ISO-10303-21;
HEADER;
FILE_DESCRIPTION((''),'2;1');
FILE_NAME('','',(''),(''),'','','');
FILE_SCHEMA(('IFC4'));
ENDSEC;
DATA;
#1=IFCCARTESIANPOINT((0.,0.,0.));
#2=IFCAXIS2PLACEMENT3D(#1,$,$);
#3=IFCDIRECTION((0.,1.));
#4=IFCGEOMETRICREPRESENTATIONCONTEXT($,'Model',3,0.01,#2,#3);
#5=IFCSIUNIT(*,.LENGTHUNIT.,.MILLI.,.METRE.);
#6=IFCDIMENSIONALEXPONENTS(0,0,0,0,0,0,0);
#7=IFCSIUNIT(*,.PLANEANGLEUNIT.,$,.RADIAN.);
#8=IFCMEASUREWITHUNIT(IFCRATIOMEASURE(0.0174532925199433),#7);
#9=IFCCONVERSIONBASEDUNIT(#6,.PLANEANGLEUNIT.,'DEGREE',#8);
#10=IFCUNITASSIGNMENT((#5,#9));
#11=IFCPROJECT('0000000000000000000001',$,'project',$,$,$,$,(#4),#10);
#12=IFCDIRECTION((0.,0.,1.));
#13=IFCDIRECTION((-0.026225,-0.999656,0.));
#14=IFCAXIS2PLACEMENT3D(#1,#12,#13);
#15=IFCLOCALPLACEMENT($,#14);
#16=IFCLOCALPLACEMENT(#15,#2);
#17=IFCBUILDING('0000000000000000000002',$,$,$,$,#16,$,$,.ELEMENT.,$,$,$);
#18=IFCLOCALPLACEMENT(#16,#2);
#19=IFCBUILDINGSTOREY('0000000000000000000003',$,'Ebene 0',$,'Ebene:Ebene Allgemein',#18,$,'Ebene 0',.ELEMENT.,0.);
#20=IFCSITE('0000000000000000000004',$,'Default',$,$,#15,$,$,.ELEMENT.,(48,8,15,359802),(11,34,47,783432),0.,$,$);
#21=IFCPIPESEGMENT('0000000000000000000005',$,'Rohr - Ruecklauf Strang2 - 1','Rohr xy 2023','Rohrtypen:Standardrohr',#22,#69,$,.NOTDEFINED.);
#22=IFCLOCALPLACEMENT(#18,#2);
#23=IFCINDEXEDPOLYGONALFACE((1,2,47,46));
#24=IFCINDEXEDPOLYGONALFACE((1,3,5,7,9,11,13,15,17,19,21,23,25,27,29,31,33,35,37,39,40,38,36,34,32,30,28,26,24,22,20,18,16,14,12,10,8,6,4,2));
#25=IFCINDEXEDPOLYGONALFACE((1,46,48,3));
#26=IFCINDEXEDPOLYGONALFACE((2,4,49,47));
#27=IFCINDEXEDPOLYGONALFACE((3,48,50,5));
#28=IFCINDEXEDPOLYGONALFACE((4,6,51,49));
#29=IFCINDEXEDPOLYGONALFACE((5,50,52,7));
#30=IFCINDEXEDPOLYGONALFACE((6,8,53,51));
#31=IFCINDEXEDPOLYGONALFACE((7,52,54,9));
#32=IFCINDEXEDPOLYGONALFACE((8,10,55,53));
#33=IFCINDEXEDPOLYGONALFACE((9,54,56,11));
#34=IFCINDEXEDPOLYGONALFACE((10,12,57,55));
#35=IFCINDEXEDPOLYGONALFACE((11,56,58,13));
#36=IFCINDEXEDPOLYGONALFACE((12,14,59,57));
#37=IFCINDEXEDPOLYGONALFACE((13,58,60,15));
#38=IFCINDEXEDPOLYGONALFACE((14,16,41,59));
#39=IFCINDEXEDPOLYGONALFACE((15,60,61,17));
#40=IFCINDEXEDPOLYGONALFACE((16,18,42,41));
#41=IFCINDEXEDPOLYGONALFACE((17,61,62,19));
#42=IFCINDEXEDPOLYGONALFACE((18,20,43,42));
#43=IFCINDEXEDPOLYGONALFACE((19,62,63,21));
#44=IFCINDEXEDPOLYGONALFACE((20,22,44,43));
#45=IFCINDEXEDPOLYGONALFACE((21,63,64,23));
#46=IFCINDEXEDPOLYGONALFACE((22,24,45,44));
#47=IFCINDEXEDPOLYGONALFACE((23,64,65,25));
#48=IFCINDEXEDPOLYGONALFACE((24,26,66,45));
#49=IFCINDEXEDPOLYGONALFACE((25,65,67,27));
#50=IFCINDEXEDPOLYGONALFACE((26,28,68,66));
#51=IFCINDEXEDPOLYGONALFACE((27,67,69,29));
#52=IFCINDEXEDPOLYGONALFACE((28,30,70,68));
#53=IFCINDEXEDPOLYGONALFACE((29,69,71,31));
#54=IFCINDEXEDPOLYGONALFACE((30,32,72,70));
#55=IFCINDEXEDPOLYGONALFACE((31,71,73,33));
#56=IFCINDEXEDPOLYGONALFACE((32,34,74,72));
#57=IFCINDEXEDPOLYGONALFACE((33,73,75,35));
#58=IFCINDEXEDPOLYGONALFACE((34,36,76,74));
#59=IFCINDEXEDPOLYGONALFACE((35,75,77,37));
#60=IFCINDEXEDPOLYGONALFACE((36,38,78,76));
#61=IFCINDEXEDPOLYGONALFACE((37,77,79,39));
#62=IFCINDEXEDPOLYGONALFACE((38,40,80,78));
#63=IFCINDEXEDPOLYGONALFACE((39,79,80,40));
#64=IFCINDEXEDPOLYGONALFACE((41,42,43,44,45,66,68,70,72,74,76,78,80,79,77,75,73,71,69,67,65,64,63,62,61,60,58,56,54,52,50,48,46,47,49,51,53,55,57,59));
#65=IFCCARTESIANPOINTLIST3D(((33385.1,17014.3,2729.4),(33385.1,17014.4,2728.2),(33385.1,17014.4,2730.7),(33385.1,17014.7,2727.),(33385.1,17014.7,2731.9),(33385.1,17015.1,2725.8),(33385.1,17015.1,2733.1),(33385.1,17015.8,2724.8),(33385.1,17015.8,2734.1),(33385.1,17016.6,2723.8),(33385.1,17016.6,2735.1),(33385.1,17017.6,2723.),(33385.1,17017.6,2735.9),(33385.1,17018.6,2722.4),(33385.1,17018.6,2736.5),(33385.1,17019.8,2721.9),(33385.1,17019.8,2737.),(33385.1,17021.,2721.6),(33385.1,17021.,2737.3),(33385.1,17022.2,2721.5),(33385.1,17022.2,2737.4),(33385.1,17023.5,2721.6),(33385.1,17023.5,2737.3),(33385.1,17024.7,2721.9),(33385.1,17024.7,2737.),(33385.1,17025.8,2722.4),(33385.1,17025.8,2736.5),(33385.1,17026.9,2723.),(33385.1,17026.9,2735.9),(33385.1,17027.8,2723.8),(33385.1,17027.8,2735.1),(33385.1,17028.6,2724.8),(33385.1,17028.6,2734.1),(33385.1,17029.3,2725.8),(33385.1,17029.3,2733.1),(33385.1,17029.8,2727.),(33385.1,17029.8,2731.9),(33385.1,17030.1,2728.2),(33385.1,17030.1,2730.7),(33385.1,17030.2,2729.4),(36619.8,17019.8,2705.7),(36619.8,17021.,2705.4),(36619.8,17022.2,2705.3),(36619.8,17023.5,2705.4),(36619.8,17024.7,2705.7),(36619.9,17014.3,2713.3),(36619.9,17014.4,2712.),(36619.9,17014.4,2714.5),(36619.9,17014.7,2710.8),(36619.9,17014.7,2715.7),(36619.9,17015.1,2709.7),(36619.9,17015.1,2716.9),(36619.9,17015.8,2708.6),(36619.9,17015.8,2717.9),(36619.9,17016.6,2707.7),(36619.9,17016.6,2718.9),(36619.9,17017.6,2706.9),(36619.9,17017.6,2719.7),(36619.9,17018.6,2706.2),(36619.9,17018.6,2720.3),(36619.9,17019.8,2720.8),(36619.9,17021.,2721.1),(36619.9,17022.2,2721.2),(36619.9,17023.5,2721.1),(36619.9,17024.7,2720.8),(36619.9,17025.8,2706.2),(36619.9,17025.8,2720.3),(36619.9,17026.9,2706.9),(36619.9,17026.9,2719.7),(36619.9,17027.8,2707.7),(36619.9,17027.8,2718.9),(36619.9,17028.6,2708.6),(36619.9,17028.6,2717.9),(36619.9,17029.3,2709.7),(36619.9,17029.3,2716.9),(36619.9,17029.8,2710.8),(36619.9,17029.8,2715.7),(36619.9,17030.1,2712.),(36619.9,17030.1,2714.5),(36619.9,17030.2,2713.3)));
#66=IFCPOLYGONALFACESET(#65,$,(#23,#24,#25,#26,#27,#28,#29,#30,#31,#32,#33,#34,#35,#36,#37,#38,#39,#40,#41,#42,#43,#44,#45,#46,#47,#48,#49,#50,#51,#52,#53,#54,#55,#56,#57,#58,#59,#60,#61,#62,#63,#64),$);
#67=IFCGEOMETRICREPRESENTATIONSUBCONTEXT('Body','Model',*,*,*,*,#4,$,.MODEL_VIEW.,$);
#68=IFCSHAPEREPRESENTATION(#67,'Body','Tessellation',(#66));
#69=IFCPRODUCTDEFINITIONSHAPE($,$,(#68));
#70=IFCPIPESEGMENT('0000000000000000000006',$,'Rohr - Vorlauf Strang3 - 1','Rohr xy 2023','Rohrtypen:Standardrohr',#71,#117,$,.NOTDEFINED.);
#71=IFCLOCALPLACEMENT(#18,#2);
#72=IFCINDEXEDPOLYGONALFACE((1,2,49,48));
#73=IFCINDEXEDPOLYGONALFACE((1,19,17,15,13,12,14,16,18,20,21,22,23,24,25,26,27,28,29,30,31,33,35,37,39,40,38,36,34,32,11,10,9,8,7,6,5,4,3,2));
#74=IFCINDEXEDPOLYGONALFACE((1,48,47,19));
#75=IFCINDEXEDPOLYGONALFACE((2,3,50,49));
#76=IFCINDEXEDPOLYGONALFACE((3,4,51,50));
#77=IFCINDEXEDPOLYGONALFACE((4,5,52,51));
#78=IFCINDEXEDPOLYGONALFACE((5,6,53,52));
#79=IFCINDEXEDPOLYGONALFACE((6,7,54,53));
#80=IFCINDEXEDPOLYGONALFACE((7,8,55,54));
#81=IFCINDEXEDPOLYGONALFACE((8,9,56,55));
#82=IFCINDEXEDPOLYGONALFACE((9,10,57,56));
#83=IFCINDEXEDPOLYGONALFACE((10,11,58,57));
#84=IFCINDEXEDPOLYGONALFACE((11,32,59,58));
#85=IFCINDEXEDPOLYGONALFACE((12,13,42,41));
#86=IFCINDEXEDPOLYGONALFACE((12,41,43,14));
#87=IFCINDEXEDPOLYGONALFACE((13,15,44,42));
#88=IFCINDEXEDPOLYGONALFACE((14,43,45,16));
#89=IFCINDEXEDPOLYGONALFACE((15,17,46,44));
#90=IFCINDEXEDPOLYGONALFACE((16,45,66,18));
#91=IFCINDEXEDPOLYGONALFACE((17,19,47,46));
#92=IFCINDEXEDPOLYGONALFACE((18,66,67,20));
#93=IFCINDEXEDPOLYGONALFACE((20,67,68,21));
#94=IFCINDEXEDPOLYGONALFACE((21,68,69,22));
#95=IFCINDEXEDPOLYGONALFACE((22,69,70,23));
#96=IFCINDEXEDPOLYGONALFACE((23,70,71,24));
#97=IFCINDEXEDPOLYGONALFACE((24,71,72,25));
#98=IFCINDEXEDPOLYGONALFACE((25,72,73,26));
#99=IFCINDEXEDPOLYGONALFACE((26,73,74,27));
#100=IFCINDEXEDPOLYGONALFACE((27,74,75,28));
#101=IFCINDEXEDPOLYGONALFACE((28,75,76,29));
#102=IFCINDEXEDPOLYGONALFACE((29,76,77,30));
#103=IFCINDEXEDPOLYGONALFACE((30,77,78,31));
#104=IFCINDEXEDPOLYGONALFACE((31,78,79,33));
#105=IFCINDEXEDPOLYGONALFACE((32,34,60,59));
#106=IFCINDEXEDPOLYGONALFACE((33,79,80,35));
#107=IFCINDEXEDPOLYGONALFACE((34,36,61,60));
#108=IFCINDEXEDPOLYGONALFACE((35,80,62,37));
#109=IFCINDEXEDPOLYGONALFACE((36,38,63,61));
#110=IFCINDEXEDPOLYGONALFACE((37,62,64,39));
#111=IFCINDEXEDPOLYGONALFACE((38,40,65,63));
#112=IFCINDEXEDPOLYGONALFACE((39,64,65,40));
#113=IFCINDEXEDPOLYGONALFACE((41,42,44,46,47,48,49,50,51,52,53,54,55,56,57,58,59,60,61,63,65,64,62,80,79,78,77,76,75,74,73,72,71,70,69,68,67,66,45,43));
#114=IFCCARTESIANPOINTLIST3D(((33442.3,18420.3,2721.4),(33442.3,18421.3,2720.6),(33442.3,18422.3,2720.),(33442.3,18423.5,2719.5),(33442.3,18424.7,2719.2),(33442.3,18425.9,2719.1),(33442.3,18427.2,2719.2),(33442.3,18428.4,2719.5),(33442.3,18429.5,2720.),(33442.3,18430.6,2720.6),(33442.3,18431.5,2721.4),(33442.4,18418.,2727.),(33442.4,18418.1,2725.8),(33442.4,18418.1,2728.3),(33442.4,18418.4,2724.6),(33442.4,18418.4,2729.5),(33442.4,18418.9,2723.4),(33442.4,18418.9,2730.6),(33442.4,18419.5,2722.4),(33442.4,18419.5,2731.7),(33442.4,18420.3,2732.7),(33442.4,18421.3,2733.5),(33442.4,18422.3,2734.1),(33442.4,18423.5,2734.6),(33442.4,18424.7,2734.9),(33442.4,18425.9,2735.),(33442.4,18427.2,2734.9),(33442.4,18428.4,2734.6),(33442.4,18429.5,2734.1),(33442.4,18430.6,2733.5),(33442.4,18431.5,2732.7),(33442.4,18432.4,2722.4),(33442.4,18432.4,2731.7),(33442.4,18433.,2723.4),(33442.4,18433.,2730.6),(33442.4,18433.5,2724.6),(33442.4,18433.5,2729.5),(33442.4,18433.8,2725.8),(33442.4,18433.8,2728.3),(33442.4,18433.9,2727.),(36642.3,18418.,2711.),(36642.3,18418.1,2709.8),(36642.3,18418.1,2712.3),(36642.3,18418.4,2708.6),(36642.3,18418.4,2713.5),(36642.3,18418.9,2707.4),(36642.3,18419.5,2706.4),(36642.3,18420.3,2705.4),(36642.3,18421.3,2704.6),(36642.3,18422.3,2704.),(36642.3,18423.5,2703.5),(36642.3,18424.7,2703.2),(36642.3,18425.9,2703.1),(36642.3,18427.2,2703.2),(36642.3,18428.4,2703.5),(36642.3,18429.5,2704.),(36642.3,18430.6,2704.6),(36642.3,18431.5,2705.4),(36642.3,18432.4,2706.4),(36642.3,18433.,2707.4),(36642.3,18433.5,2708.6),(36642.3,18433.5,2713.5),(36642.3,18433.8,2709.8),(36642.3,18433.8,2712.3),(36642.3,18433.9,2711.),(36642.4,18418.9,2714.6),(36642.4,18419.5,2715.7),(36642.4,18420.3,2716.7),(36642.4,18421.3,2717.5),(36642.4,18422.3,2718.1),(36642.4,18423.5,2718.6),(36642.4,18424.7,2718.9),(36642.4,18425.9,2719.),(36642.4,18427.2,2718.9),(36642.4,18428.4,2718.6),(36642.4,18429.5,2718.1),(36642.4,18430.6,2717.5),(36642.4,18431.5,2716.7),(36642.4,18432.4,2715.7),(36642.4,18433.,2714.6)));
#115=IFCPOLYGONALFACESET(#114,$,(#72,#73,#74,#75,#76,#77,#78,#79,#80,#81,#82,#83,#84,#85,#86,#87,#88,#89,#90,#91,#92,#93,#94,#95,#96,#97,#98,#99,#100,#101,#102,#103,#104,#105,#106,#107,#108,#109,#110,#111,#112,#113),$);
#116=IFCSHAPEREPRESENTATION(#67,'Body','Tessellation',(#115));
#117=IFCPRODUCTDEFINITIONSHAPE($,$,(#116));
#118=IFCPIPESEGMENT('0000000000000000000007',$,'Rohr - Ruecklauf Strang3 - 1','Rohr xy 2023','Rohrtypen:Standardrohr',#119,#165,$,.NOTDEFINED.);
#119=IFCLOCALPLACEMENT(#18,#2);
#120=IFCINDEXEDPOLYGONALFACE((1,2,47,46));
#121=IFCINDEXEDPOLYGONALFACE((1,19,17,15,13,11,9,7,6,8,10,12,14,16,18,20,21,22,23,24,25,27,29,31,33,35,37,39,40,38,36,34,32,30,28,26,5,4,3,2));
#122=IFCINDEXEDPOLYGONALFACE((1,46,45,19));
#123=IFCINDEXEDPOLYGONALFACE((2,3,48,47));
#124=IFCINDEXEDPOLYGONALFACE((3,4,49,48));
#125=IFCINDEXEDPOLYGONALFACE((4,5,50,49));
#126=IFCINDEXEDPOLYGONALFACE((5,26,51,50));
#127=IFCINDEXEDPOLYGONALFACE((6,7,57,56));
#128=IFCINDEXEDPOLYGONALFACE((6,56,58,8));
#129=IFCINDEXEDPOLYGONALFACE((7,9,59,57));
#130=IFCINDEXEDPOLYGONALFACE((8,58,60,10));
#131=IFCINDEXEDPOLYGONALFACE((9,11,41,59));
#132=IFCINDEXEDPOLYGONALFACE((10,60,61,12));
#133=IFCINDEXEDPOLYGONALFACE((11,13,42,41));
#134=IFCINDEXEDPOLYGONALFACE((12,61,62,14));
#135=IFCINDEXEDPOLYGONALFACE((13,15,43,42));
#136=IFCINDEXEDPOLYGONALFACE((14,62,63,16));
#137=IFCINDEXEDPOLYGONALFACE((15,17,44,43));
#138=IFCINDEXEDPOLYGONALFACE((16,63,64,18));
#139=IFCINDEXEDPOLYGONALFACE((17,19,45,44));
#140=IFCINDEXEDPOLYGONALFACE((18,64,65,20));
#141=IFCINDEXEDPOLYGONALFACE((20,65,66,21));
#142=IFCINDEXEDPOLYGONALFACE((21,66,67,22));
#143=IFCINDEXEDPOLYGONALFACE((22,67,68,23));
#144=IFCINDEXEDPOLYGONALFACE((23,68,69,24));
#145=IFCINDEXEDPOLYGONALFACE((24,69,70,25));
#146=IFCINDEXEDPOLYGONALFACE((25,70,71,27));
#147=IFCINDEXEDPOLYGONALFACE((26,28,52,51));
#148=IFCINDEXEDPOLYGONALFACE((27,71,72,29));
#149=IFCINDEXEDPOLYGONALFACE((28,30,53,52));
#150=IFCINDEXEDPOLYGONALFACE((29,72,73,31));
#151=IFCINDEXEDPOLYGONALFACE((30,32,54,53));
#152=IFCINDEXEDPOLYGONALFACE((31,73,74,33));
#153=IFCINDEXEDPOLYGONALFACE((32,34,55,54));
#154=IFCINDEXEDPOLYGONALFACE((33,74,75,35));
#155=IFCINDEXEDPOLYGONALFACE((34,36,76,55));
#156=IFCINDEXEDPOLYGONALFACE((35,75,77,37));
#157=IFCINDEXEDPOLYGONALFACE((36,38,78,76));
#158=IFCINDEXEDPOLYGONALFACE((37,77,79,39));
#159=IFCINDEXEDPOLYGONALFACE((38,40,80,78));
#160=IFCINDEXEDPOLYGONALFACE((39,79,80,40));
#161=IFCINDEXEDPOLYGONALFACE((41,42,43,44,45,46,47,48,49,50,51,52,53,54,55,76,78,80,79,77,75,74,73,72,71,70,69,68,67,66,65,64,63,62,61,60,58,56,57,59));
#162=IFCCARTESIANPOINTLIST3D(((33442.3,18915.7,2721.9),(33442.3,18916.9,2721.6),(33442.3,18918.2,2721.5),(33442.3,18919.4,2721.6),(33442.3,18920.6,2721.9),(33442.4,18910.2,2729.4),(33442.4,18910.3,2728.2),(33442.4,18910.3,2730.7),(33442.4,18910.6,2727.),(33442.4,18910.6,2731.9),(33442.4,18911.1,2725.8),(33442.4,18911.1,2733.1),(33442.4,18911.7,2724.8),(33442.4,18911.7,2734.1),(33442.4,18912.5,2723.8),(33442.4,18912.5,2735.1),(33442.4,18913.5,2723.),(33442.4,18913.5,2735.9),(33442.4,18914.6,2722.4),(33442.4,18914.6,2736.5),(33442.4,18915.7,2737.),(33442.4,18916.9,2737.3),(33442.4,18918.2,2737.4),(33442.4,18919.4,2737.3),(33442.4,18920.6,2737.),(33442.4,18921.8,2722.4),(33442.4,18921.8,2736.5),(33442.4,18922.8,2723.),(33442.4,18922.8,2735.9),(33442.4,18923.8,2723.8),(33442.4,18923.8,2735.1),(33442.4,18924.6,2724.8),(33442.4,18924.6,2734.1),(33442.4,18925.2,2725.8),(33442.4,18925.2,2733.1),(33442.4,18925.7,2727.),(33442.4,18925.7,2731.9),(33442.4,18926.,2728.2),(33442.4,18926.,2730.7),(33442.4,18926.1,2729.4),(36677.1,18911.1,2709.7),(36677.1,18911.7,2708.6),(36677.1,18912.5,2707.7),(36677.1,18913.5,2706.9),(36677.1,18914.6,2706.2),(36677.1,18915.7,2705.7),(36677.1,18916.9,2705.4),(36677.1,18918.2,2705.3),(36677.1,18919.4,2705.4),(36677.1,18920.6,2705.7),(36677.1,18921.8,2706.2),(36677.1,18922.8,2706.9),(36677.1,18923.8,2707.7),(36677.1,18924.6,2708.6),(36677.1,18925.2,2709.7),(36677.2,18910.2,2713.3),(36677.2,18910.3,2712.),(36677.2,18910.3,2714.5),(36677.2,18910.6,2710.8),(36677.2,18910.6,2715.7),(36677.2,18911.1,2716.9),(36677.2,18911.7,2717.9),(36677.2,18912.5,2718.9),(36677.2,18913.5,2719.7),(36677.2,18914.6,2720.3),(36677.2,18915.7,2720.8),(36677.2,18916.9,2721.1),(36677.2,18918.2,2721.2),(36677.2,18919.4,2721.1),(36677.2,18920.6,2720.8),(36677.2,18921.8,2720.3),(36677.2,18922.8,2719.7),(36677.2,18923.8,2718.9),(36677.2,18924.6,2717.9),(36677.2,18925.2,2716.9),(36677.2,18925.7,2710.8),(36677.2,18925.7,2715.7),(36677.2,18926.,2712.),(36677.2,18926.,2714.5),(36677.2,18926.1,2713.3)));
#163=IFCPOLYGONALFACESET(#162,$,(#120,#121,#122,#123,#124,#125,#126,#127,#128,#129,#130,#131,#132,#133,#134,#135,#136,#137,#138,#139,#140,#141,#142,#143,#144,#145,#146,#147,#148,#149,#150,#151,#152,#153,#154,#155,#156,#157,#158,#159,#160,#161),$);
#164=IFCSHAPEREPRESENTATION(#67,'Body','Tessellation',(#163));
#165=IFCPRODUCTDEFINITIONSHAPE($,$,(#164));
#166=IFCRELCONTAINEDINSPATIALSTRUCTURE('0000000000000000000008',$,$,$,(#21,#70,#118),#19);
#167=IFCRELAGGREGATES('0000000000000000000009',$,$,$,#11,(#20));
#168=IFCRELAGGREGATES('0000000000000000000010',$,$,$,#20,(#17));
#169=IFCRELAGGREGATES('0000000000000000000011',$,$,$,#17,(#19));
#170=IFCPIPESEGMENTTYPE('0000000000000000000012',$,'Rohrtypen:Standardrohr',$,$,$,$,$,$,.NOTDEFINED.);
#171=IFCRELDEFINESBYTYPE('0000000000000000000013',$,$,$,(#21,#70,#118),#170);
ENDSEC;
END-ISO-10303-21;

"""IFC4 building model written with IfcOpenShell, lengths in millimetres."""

from ifc_helpers import new_model, entity, si_unit, converted_unit, direction, frame, origin, place, context, subcontext, project, spatial, indexed_curve, outline, extrude, type_object, element, save


model = new_model("IFC4")

# Units and contexts
model_context = context("Model", 3, precision=0.01, world=origin(), true_north=direction((0.0, 1.0)))
body_context = subcontext(model_context, "Body", "Model", "MODEL_VIEW")
ifc_project = project(units=[si_unit("LENGTHUNIT", "METRE", prefix="MILLI"), converted_unit("PLANEANGLEUNIT", "DEGREE", entity("IfcRatioMeasure", 0.0174532925199433), si_unit("PLANEANGLEUNIT", "RADIAN"), dimensions=[0, 0, 0, 0, 0, 0, 0])], contexts=[model_context])

# Site, building, storey
site_placement = place(None, frame((0.0, 0.0, 0.0), z_axis=(0.0, 0.0, 1.0), x_axis=(-0.026225, -0.999656, 0.0)))
site = spatial("IfcSite", under=ifc_project, at=site_placement, Name="Default", CompositionType="ELEMENT", RefLatitude=(48, 8, 15, 359802), RefLongitude=(11, 34, 47, 783432), RefElevation=0.0)
building_placement = place(site_placement, origin())
building = spatial("IfcBuilding", under=site, at=building_placement, CompositionType="ELEMENT")
storey_placement = place(building_placement, origin())
storey = spatial("IfcBuildingStorey", under=building, at=storey_placement, Name="Ebene 0", ObjectType="Ebene:Ebene Allgemein", LongName="Ebene 0", CompositionType="ELEMENT", Elevation=0.0)

# Pipe segments
pipe_segment_type = type_object("IfcPipeSegmentType", Name="Rohrtypen:Standardrohr", PredefinedType="NOTDEFINED")
pipe_segment_1_placement = place(storey_placement, origin())
element("IfcPipeSegment", 1, at=pipe_segment_1_placement, inside=storey, type_object=pipe_segment_type, Name="Rohr - Ruecklauf Strang2 - 1", Description="Rohr xy 2023", ObjectType="Rohrtypen:Standardrohr", PredefinedType="NOTDEFINED", context=body_context, shape_type="SweptSolid", body=[
    extrude(outline(indexed_curve([(7.9, 0.0), (7.8, 1.2), (7.6, 2.5), (7.1, 3.6), (6.4, 4.7), (5.6, 5.6), (4.7, 6.4), (3.6, 7.1), (2.5, 7.6), (1.2, 7.8), (0.0, 7.9), (-1.2, 7.8), (-2.5, 7.6), (-3.6, 7.1), (-4.7, 6.4), (-5.6, 5.6), (-6.4, 4.7), (-7.1, 3.6), (-7.6, 2.5), (-7.8, 1.2), (-7.9, 0.0), (-7.8, -1.2), (-7.6, -2.5), (-7.1, -3.6), (-6.4, -4.7), (-5.6, -5.6), (-4.7, -6.4), (-3.6, -7.1), (-2.5, -7.6), (-1.2, -7.8), (0.0, -7.9), (1.2, -7.8), (2.5, -7.6), (3.6, -7.1), (4.7, -6.4), (5.6, -5.6), (6.4, -4.7), (7.1, -3.6), (7.6, -2.5), (7.8, -1.2), (7.9, 0.0)], self_intersect=False)), frame((36619.9, 17022.2, 2713.3), z_axis=(-0.999988, 0.0, 0.005), x_axis=(0.0, 1.0, 0.0)), (0.0, 0.0, 1.0), 3234.8),
])
pipe_segment_2_placement = place(storey_placement, origin())
element("IfcPipeSegment", 2, at=pipe_segment_2_placement, inside=storey, type_object=pipe_segment_type, Name="Rohr - Vorlauf Strang3 - 1", Description="Rohr xy 2023", ObjectType="Rohrtypen:Standardrohr", PredefinedType="NOTDEFINED", context=body_context, shape_type="SweptSolid", body=[
    extrude(outline(indexed_curve([(7.9, 0.0), (7.8, 1.2), (7.6, 2.5), (7.1, 3.6), (6.4, 4.7), (5.6, 5.6), (4.7, 6.4), (3.6, 7.1), (2.5, 7.6), (1.2, 7.8), (0.0, 7.9), (-1.2, 7.8), (-2.5, 7.6), (-3.6, 7.1), (-4.7, 6.4), (-5.6, 5.6), (-6.4, 4.7), (-7.1, 3.6), (-7.6, 2.5), (-7.8, 1.2), (-7.9, 0.0), (-7.8, -1.2), (-7.6, -2.5), (-7.1, -3.6), (-6.4, -4.7), (-5.6, -5.6), (-4.7, -6.4), (-3.6, -7.1), (-2.5, -7.6), (-1.2, -7.8), (0.0, -7.9), (1.2, -7.8), (2.5, -7.6), (3.6, -7.1), (4.7, -6.4), (5.6, -5.6), (6.4, -4.7), (7.1, -3.6), (7.6, -2.5), (7.8, -1.2), (7.9, 0.0)], self_intersect=False)), frame((36642.3, 18425.9, 2711.0), z_axis=(-0.999988, 0.0, 0.005), x_axis=(0.0, 1.0, 0.0)), (0.0, 0.0, 1.0), 3200.0),
])
pipe_segment_3_placement = place(storey_placement, origin())
element("IfcPipeSegment", 3, at=pipe_segment_3_placement, inside=storey, type_object=pipe_segment_type, Name="Rohr - Ruecklauf Strang3 - 1", Description="Rohr xy 2023", ObjectType="Rohrtypen:Standardrohr", PredefinedType="NOTDEFINED", context=body_context, shape_type="SweptSolid", body=[
    extrude(outline(indexed_curve([(7.9, 0.0), (7.8, 1.2), (7.6, 2.5), (7.1, 3.6), (6.4, 4.7), (5.6, 5.6), (4.7, 6.4), (3.6, 7.1), (2.5, 7.6), (1.2, 7.8), (0.0, 7.9), (-1.2, 7.8), (-2.5, 7.6), (-3.6, 7.1), (-4.7, 6.4), (-5.6, 5.6), (-6.4, 4.7), (-7.1, 3.6), (-7.6, 2.5), (-7.8, 1.2), (-7.9, 0.0), (-7.8, -1.2), (-7.6, -2.5), (-7.1, -3.6), (-6.4, -4.7), (-5.6, -5.6), (-4.7, -6.4), (-3.6, -7.1), (-2.5, -7.6), (-1.2, -7.8), (0.0, -7.9), (1.2, -7.8), (2.5, -7.6), (3.6, -7.1), (4.7, -6.4), (5.6, -5.6), (6.4, -4.7), (7.1, -3.6), (7.6, -2.5), (7.8, -1.2), (7.9, 0.0)], self_intersect=False)), frame((36677.2, 18918.2, 2713.3), z_axis=(-0.999988, 0.0, 0.005), x_axis=(0.0, 1.0, 0.0)), (0.0, 0.0, 1.0), 3234.8),
])

save(model, "model.ifc")
